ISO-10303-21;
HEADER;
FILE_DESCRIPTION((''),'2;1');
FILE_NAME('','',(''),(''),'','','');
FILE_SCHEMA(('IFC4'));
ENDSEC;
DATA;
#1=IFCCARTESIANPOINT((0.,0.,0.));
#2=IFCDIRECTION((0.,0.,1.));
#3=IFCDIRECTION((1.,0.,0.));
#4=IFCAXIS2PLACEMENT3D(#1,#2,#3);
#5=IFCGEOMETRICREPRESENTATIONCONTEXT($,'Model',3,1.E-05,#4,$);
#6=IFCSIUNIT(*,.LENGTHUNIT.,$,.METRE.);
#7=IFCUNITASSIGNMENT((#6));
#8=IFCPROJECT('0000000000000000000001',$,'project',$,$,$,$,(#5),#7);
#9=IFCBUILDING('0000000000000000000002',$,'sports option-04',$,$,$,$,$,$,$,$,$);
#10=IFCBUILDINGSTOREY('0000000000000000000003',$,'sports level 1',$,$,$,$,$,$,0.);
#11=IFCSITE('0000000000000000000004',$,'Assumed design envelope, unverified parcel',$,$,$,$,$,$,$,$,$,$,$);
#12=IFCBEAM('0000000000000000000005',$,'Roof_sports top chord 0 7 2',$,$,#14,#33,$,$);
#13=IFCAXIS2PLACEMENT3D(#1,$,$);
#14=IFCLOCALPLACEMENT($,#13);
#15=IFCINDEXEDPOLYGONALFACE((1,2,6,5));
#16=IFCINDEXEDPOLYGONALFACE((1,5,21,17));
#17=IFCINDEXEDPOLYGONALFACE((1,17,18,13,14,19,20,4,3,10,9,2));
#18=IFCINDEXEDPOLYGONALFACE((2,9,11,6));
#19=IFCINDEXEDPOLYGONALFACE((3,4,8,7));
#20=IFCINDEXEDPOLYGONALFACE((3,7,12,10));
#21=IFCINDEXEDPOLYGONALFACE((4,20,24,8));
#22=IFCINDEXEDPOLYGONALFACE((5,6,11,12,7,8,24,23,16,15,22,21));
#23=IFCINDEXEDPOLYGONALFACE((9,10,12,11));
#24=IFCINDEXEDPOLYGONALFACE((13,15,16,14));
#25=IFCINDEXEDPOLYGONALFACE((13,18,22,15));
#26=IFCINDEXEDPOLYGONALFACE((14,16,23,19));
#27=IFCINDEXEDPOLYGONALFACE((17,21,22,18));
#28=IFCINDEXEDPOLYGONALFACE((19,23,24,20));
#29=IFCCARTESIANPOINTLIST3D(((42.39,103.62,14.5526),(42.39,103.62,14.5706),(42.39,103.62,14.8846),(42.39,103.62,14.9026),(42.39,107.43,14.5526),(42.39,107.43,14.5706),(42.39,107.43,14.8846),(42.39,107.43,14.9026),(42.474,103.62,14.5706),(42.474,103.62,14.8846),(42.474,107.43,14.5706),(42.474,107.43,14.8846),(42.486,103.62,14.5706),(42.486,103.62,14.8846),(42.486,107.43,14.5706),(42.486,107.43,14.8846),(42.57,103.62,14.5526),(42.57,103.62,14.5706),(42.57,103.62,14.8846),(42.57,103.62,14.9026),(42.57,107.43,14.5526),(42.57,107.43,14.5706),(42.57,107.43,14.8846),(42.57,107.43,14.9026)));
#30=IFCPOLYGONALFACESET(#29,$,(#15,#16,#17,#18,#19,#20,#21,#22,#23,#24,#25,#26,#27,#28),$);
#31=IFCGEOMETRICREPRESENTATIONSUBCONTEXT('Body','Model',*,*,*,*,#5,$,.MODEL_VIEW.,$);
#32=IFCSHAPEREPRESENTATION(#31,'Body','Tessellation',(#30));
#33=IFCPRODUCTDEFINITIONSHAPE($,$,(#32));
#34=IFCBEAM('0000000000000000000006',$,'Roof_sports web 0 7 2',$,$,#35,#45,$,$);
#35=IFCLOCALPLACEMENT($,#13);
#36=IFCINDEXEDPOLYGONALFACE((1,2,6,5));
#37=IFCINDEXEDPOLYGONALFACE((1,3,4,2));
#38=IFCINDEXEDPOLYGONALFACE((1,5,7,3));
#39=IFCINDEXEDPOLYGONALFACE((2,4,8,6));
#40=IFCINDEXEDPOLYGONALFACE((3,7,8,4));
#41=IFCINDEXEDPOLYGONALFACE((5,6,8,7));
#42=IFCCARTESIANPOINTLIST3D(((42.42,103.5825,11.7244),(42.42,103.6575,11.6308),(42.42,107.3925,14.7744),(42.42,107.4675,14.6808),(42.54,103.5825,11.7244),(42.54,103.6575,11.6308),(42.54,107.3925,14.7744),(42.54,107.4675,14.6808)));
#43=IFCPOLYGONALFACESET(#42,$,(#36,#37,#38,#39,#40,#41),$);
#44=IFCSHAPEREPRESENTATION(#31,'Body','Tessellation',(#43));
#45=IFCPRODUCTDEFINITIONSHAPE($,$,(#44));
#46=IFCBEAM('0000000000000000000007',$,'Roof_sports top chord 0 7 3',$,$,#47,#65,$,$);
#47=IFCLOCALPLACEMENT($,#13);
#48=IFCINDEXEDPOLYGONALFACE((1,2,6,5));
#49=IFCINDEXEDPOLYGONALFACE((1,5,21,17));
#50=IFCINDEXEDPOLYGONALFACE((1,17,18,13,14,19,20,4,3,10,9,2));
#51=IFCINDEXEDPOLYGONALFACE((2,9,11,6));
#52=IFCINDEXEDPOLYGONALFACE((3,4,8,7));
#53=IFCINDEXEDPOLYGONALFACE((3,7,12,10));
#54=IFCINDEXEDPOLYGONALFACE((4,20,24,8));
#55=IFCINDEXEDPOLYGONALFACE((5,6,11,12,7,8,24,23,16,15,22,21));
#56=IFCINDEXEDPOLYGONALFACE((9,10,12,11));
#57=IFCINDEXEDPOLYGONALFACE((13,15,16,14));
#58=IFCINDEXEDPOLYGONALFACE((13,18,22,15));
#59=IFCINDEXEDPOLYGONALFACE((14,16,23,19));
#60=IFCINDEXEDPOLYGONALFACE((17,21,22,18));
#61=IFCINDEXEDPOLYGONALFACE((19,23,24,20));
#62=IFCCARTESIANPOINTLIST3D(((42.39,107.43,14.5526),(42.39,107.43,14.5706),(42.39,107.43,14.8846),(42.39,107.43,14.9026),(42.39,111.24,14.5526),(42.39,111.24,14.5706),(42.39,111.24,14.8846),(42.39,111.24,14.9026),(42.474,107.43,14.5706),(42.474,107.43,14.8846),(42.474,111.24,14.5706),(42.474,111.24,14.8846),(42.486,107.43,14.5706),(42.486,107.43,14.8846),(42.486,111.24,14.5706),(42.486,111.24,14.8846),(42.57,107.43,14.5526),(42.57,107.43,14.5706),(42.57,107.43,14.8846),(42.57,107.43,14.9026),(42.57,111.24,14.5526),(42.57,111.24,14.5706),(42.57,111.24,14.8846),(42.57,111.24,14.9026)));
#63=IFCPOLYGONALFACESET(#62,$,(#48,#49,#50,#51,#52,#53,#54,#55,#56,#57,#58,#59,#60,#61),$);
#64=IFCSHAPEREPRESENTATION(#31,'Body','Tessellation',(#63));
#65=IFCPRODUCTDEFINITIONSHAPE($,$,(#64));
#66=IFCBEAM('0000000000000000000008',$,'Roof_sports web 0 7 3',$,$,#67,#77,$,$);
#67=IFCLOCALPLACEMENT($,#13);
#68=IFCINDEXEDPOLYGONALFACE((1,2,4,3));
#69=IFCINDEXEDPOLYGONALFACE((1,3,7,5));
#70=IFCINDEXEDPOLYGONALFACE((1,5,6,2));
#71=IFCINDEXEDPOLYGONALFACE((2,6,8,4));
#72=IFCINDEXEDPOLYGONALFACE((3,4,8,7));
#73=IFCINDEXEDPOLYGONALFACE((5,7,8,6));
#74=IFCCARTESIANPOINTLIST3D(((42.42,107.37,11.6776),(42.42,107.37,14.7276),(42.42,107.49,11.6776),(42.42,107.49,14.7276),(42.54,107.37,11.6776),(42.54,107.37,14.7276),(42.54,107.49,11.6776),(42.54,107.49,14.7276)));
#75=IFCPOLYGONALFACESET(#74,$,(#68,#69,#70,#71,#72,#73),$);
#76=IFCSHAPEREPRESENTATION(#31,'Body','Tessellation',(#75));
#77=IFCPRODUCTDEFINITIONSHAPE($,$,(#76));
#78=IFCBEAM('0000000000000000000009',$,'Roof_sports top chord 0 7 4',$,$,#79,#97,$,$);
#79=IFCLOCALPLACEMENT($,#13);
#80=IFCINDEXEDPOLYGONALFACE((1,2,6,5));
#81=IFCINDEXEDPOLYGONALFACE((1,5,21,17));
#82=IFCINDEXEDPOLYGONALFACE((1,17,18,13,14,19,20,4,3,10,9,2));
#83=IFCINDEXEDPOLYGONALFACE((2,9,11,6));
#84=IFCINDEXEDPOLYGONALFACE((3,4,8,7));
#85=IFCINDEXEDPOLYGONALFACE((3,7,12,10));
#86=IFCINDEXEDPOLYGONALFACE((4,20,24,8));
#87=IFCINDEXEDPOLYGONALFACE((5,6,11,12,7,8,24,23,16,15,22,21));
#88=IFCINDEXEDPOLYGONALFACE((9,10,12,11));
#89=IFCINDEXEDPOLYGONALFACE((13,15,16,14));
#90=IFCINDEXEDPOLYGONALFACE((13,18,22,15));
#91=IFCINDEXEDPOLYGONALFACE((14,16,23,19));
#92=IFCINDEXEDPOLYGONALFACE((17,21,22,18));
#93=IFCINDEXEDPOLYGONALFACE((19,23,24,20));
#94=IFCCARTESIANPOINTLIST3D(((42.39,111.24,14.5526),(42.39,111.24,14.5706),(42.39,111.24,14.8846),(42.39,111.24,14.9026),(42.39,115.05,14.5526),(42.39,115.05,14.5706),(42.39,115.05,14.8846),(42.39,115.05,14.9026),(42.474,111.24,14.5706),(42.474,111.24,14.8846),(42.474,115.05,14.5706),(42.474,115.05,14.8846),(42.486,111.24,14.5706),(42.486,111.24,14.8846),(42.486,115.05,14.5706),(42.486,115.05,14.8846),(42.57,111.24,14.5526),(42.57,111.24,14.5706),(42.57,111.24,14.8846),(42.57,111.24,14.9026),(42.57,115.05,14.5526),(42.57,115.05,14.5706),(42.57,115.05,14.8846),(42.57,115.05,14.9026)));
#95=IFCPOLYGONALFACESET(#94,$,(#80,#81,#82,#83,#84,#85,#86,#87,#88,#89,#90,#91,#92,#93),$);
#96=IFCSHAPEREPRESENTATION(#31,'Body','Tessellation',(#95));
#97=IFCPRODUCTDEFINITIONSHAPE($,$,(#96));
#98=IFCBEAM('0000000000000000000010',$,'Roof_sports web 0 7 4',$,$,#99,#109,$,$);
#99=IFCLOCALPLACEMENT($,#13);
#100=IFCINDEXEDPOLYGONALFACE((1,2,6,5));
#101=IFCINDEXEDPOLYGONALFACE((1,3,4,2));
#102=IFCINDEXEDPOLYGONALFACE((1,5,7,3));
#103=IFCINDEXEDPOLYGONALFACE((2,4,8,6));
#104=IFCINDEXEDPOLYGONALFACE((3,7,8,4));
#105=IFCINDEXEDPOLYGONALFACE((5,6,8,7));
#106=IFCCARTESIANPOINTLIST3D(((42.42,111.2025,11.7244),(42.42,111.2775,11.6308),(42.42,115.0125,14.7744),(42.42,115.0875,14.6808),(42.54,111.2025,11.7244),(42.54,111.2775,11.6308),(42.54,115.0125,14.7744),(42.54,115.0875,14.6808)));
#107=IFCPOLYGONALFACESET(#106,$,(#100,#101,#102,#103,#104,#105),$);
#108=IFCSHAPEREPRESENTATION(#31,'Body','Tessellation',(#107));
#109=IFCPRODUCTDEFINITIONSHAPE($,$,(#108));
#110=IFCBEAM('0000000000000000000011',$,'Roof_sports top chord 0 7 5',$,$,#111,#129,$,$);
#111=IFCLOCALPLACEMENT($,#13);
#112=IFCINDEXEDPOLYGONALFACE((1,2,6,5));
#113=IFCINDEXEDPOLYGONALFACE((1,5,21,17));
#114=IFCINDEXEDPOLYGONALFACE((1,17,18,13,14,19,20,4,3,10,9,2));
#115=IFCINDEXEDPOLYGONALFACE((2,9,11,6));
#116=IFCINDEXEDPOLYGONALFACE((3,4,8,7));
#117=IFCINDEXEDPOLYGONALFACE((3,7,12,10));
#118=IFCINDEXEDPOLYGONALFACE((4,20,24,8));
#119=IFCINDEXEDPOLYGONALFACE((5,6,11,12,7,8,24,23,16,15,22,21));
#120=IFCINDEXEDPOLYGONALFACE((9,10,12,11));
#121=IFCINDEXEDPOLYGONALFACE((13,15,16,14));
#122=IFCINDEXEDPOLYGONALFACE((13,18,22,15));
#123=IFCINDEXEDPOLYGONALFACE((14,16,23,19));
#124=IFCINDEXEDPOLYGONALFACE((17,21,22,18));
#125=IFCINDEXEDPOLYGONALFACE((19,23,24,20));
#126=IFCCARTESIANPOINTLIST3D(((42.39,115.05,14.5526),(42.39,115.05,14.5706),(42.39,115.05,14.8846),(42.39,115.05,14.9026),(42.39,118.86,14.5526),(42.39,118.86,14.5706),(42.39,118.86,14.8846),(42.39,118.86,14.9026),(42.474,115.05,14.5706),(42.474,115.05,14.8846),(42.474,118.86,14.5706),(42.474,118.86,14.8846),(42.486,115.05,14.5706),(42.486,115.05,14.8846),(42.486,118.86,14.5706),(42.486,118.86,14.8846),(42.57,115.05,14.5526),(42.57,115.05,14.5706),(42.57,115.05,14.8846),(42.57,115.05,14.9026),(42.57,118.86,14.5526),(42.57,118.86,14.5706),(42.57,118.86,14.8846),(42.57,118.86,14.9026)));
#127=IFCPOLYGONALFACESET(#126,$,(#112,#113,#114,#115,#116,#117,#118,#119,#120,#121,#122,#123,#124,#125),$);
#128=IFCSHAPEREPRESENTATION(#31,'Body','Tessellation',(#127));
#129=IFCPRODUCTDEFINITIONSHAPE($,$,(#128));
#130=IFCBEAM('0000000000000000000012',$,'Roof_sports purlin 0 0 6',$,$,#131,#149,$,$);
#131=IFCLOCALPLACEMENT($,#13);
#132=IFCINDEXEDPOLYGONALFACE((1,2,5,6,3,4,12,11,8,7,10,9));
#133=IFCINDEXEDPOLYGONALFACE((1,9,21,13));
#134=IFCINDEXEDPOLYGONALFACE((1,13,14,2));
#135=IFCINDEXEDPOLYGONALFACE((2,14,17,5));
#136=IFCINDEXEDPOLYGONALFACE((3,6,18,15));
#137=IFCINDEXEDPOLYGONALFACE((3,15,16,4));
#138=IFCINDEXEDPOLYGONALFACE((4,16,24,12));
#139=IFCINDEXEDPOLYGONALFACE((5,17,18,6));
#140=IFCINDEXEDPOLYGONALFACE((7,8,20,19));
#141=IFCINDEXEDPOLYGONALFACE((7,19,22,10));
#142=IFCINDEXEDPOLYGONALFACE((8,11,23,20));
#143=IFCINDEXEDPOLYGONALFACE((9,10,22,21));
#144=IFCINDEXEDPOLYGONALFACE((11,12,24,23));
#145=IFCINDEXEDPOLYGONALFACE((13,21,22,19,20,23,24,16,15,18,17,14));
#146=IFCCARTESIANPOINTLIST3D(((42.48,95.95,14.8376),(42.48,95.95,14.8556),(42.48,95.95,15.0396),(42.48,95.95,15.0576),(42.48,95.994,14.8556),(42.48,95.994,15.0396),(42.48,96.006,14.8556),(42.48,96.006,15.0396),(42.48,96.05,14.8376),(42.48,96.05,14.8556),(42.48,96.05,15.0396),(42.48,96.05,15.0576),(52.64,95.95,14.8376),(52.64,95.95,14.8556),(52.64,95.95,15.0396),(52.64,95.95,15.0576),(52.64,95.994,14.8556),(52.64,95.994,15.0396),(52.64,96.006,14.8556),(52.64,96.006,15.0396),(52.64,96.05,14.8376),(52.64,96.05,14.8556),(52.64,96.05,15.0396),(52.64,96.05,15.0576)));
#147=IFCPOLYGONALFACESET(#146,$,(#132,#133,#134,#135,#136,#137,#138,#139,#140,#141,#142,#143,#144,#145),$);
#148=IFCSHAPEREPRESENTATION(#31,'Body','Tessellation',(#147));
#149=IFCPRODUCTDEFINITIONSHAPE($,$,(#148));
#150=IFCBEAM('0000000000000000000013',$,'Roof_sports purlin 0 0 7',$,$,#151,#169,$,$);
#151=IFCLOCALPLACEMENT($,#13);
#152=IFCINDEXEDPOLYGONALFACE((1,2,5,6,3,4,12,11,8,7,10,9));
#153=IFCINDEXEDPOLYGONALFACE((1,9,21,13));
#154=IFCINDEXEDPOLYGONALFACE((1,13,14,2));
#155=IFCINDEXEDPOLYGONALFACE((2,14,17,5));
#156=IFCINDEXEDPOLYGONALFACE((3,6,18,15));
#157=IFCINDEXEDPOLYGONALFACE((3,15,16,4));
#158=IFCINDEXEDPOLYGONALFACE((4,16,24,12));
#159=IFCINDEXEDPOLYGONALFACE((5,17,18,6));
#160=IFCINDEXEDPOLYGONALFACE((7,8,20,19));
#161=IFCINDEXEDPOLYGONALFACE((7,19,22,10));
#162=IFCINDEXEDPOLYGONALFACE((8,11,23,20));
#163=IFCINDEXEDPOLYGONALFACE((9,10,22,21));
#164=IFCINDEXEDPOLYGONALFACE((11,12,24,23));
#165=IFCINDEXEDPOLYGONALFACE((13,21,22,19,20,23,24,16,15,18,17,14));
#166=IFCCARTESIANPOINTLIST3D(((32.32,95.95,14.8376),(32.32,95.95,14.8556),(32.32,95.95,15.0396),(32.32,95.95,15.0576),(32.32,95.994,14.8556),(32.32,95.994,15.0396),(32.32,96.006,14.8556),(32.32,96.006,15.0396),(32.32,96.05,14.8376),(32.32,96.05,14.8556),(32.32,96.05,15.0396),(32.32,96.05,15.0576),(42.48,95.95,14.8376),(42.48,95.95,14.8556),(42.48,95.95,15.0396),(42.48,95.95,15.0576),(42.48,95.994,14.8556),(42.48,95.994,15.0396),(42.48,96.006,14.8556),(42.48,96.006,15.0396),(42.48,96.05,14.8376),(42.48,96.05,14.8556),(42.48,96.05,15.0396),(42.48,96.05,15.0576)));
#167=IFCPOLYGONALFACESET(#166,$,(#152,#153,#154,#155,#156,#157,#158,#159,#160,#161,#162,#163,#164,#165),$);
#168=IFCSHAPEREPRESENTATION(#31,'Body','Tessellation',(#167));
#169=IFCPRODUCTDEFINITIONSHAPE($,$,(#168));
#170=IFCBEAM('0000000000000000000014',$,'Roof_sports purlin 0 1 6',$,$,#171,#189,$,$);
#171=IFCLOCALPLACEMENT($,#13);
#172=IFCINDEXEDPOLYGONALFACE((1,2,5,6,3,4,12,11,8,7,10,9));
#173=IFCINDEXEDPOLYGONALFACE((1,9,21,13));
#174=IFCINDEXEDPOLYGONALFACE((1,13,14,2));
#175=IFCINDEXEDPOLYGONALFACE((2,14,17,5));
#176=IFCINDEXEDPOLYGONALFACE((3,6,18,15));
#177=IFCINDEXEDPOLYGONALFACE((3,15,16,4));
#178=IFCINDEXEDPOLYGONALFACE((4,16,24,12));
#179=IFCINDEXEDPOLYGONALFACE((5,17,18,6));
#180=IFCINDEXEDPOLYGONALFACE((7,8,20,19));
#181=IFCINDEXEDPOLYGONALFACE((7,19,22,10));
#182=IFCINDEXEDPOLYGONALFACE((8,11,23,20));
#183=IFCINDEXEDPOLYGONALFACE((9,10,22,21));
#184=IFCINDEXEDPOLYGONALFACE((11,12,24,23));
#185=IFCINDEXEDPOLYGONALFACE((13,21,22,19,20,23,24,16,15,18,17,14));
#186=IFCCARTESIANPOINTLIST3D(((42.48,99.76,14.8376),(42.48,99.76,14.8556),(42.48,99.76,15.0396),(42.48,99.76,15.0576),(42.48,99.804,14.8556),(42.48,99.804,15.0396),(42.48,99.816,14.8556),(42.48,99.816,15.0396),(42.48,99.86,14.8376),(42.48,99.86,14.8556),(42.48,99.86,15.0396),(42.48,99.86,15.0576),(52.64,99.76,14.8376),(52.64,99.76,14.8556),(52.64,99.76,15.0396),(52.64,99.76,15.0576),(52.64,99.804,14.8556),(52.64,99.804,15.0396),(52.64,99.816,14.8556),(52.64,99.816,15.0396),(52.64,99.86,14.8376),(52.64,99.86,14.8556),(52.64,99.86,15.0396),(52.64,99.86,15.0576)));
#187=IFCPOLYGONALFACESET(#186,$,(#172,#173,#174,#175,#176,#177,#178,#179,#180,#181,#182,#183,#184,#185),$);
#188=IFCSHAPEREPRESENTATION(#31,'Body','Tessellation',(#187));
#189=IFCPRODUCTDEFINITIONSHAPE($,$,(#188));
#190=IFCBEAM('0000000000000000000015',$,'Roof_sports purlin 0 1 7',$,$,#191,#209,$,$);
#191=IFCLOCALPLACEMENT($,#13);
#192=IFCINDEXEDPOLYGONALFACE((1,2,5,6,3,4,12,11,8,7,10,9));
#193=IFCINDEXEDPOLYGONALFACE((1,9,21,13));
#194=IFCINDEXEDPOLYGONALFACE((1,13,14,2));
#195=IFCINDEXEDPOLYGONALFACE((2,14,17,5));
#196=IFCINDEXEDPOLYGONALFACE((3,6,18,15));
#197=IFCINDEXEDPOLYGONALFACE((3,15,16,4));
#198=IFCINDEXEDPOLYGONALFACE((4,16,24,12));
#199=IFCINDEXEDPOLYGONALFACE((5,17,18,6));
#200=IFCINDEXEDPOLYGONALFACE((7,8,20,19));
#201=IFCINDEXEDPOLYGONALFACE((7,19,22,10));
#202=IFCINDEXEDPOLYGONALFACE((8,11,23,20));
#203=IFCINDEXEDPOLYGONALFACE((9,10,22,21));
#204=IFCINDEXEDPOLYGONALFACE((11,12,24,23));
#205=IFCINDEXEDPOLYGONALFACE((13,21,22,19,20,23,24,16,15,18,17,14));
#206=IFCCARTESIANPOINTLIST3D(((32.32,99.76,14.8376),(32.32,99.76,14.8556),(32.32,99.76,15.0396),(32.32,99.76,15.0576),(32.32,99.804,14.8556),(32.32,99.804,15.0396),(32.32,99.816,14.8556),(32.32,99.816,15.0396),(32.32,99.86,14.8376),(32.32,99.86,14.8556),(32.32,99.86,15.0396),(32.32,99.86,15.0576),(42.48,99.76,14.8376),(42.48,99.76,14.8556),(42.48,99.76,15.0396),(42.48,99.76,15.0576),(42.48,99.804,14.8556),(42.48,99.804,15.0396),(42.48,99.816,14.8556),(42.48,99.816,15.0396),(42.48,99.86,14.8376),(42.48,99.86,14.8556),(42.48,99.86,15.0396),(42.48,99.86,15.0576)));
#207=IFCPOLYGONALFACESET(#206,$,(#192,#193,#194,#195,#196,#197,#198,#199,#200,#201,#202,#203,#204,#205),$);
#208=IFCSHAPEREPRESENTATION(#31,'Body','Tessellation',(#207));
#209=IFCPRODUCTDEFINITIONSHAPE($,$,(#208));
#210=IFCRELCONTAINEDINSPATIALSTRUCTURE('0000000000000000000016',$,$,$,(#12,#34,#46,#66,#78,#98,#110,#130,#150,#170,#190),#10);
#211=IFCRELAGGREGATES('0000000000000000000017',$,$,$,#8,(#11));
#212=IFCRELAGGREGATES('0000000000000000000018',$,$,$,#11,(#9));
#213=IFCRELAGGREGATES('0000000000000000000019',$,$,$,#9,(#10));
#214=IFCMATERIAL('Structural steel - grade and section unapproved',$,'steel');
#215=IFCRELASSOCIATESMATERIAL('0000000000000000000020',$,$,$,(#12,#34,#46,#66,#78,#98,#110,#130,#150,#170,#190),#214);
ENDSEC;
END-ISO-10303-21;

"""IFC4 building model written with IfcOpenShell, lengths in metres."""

from ifc_helpers import new_model, si_unit, frame, origin_with_axes, place, context, subcontext, project, spatial, rectangle, i_section, extrude, material, element, save


model = new_model("IFC4")

# Units and contexts
model_context = context("Model", 3, precision=1e-05, world=origin_with_axes())
body_context = subcontext(model_context, "Body", "Model", "MODEL_VIEW")
ifc_project = project(units=[si_unit("LENGTHUNIT", "METRE")], contexts=[model_context])

# Site, building, storey
site = spatial("IfcSite", under=ifc_project, Name="Assumed design envelope, unverified parcel")
building = spatial("IfcBuilding", under=site, Name="sports option-04")
storey = spatial("IfcBuildingStorey", under=building, Name="sports level 1", Elevation=0.0)

# Shared definitions
ifc_material_1 = material(Name="Structural steel - grade and section unapproved", Category="steel")

# Beams
beam_1_placement = place(None, frame((42.48, 103.62, 14.7276), z_axis=(0.0, 1.0, 0.0), x_axis=(-1.0, 0.0, 0.0)))
element("IfcBeam", 1, at=beam_1_placement, inside=storey, material=ifc_material_1, Name="Roof_sports top chord 0 7 2", context=body_context, shape_type="SweptSolid", body=[
    extrude(i_section(OverallWidth=0.18, OverallDepth=0.35, WebThickness=0.012, FlangeThickness=0.018, FilletRadius=0.0), origin_with_axes(), (0.0, 0.0, 1.0), 3.81),
])
beam_2_placement = place(None, frame((42.48, 103.62, 11.6776), z_axis=(0.0, 0.780669, 0.624945), x_axis=(-1.0, 0.0, 0.0)))
element("IfcBeam", 2, at=beam_2_placement, inside=storey, material=ifc_material_1, Name="Roof_sports web 0 7 2", context=body_context, shape_type="SweptSolid", body=[
    extrude(rectangle(XDim=0.12, YDim=0.12), origin_with_axes(), (0.0, 0.0, 1.0), 4.8804),
])
beam_3_placement = place(None, frame((42.48, 107.43, 14.7276), z_axis=(0.0, 1.0, 0.0), x_axis=(-1.0, 0.0, 0.0)))
element("IfcBeam", 3, at=beam_3_placement, inside=storey, material=ifc_material_1, Name="Roof_sports top chord 0 7 3", context=body_context, shape_type="SweptSolid", body=[
    extrude(i_section(OverallWidth=0.18, OverallDepth=0.35, WebThickness=0.012, FlangeThickness=0.018, FilletRadius=0.0), origin_with_axes(), (0.0, 0.0, 1.0), 3.81),
])
beam_4_placement = place(None, frame((42.48, 107.43, 11.6776), z_axis=(0.0, 0.0, 1.0), x_axis=(-1.0, 0.0, 0.0)))
element("IfcBeam", 4, at=beam_4_placement, inside=storey, material=ifc_material_1, Name="Roof_sports web 0 7 3", context=body_context, shape_type="SweptSolid", body=[
    extrude(rectangle(XDim=0.12, YDim=0.12), origin_with_axes(), (0.0, 0.0, 1.0), 3.05),
])
beam_5_placement = place(None, frame((42.48, 111.24, 14.7276), z_axis=(0.0, 1.0, 0.0), x_axis=(-1.0, 0.0, 0.0)))
element("IfcBeam", 5, at=beam_5_placement, inside=storey, material=ifc_material_1, Name="Roof_sports top chord 0 7 4", context=body_context, shape_type="SweptSolid", body=[
    extrude(i_section(OverallWidth=0.18, OverallDepth=0.35, WebThickness=0.012, FlangeThickness=0.018, FilletRadius=0.0), origin_with_axes(), (0.0, 0.0, 1.0), 3.81),
])
beam_6_placement = place(None, frame((42.48, 111.24, 11.6776), z_axis=(0.0, 0.780669, 0.624944), x_axis=(-1.0, 0.0, 0.0)))
element("IfcBeam", 6, at=beam_6_placement, inside=storey, material=ifc_material_1, Name="Roof_sports web 0 7 4", context=body_context, shape_type="SweptSolid", body=[
    extrude(rectangle(XDim=0.12, YDim=0.12), origin_with_axes(), (0.0, 0.0, 1.0), 4.8804),
])
beam_7_placement = place(None, frame((42.48, 115.05, 14.7276), z_axis=(0.0, 1.0, 0.0), x_axis=(-1.0, 0.0, 0.0)))
element("IfcBeam", 7, at=beam_7_placement, inside=storey, material=ifc_material_1, Name="Roof_sports top chord 0 7 5", context=body_context, shape_type="SweptSolid", body=[
    extrude(i_section(OverallWidth=0.18, OverallDepth=0.35, WebThickness=0.012, FlangeThickness=0.018, FilletRadius=0.0), origin_with_axes(), (0.0, 0.0, 1.0), 3.81),
])
for number, where, z_axis, x_axis, name in (
    (8, (52.64, 96.0, 14.9476), (-1.0, 0.0, 0.0), (0.0, -1.0, 0.0), "Roof_sports purlin 0 0 6"),
    (9, (42.48, 96.0, 14.9476), (-1.0, 0.0, 0.0), (0.0, -1.0, 0.0), "Roof_sports purlin 0 0 7"),
    (10, (52.64, 99.81, 14.9476), (-1.0, 0.0, 0.0), (0.0, -1.0, 0.0), "Roof_sports purlin 0 1 6"),
    (11, (42.48, 99.81, 14.9476), (-1.0, 0.0, 0.0), (0.0, -1.0, 0.0), "Roof_sports purlin 0 1 7"),
):
    element("IfcBeam", number, at=place(None, frame(where, z_axis=z_axis, x_axis=x_axis)), inside=storey, material=ifc_material_1, Name=name, context=body_context, shape_type="SweptSolid", body=[
        extrude(i_section(OverallWidth=0.1, OverallDepth=0.22, WebThickness=0.012, FlangeThickness=0.018, FilletRadius=0.0), origin_with_axes(), (0.0, 0.0, 1.0), 10.16),
    ])

save(model, "model.ifc")
